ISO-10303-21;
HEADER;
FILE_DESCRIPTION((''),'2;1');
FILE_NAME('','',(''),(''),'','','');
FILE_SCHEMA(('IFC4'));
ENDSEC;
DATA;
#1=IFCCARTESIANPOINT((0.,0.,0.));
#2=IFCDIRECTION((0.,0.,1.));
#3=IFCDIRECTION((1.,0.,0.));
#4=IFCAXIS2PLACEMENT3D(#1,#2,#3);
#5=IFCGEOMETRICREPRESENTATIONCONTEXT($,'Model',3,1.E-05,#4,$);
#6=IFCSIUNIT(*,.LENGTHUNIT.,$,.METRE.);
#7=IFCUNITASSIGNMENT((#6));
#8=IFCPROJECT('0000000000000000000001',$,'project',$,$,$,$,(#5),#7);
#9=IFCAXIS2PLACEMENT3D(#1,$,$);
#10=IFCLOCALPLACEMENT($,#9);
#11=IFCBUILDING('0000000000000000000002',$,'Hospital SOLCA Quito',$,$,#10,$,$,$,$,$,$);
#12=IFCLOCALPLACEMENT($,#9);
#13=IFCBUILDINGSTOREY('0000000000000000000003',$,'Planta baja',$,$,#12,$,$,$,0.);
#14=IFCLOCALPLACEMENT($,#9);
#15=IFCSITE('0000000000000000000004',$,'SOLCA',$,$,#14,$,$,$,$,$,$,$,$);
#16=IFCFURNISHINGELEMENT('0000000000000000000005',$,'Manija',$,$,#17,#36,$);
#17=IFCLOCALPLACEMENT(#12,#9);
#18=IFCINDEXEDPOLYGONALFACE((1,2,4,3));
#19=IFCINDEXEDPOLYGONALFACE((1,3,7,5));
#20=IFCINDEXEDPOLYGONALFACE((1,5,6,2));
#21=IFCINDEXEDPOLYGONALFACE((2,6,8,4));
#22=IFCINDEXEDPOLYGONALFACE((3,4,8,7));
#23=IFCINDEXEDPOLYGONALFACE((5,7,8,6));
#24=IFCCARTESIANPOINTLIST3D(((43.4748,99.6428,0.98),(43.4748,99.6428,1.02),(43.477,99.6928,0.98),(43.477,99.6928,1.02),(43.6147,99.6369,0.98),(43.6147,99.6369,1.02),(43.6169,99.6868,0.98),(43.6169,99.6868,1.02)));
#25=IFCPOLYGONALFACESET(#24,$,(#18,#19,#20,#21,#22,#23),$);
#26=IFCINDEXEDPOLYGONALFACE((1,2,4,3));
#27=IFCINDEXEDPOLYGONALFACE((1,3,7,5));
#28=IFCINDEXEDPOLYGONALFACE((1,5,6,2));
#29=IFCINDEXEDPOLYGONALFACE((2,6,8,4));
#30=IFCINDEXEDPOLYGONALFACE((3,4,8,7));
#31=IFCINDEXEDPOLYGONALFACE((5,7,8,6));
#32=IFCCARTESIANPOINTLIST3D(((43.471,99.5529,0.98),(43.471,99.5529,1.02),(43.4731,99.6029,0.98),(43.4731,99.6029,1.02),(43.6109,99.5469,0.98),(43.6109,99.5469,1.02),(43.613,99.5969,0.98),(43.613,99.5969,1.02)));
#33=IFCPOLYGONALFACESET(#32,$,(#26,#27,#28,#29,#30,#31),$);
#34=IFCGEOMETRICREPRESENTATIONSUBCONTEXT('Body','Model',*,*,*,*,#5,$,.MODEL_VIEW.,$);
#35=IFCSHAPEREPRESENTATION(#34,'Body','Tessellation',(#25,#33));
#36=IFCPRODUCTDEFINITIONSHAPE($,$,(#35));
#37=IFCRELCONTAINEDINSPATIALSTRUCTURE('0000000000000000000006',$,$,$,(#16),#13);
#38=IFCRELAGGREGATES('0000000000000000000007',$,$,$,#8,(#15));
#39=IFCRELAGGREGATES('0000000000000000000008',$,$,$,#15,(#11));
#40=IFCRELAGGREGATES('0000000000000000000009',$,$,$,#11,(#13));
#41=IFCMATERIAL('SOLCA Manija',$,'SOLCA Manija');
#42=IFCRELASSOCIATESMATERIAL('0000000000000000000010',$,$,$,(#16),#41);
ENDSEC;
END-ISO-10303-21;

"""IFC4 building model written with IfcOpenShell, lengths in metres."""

from ifc_helpers import new_model, si_unit, frame, origin, origin_with_axes, place, context, subcontext, project, spatial, polyline, outline, extrude, material, element, save


model = new_model("IFC4")

# Units and contexts
model_context = context("Model", 3, precision=1e-05, world=origin_with_axes())
body_context = subcontext(model_context, "Body", "Model", "MODEL_VIEW")
ifc_project = project(units=[si_unit("LENGTHUNIT", "METRE")], contexts=[model_context])

# Site, building, storey
site_placement = place(None, origin())
site = spatial("IfcSite", under=ifc_project, at=site_placement, Name="SOLCA")
building_placement = place(None, origin())
building = spatial("IfcBuilding", under=site, at=building_placement, Name="Hospital SOLCA Quito")
storey_placement = place(None, origin())
storey = spatial("IfcBuildingStorey", under=building, at=storey_placement, Name="Planta baja", Elevation=0.0)

# Furnishing element
ifc_material_1 = material(Name="SOLCA Manija", Category="SOLCA Manija")
furnishing_placement = place(storey_placement, origin_with_axes())
element("IfcFurnishingElement", 1, at=furnishing_placement, inside=storey, material=ifc_material_1, Name="Manija", context=body_context, shape_type="SweptSolid", body=[
    extrude(outline(polyline([(43.6169, 99.6868), (43.477, 99.6928), (43.4748, 99.6428), (43.6147, 99.6369), (43.6169, 99.6868)])), frame((0.0, 0.0, 0.98), z_axis=(0.0, 0.0, 1.0), x_axis=(1.0, 0.0, 0.0)), (0.0, 0.0, 1.0), 0.04),
    extrude(outline(polyline([(43.613, 99.5969), (43.4731, 99.6029), (43.471, 99.5529), (43.6109, 99.5469), (43.613, 99.5969)])), frame((0.0, 0.0, 0.98), z_axis=(0.0, 0.0, 1.0), x_axis=(1.0, 0.0, 0.0)), (0.0, 0.0, 1.0), 0.04),
])

save(model, "model.ifc")
